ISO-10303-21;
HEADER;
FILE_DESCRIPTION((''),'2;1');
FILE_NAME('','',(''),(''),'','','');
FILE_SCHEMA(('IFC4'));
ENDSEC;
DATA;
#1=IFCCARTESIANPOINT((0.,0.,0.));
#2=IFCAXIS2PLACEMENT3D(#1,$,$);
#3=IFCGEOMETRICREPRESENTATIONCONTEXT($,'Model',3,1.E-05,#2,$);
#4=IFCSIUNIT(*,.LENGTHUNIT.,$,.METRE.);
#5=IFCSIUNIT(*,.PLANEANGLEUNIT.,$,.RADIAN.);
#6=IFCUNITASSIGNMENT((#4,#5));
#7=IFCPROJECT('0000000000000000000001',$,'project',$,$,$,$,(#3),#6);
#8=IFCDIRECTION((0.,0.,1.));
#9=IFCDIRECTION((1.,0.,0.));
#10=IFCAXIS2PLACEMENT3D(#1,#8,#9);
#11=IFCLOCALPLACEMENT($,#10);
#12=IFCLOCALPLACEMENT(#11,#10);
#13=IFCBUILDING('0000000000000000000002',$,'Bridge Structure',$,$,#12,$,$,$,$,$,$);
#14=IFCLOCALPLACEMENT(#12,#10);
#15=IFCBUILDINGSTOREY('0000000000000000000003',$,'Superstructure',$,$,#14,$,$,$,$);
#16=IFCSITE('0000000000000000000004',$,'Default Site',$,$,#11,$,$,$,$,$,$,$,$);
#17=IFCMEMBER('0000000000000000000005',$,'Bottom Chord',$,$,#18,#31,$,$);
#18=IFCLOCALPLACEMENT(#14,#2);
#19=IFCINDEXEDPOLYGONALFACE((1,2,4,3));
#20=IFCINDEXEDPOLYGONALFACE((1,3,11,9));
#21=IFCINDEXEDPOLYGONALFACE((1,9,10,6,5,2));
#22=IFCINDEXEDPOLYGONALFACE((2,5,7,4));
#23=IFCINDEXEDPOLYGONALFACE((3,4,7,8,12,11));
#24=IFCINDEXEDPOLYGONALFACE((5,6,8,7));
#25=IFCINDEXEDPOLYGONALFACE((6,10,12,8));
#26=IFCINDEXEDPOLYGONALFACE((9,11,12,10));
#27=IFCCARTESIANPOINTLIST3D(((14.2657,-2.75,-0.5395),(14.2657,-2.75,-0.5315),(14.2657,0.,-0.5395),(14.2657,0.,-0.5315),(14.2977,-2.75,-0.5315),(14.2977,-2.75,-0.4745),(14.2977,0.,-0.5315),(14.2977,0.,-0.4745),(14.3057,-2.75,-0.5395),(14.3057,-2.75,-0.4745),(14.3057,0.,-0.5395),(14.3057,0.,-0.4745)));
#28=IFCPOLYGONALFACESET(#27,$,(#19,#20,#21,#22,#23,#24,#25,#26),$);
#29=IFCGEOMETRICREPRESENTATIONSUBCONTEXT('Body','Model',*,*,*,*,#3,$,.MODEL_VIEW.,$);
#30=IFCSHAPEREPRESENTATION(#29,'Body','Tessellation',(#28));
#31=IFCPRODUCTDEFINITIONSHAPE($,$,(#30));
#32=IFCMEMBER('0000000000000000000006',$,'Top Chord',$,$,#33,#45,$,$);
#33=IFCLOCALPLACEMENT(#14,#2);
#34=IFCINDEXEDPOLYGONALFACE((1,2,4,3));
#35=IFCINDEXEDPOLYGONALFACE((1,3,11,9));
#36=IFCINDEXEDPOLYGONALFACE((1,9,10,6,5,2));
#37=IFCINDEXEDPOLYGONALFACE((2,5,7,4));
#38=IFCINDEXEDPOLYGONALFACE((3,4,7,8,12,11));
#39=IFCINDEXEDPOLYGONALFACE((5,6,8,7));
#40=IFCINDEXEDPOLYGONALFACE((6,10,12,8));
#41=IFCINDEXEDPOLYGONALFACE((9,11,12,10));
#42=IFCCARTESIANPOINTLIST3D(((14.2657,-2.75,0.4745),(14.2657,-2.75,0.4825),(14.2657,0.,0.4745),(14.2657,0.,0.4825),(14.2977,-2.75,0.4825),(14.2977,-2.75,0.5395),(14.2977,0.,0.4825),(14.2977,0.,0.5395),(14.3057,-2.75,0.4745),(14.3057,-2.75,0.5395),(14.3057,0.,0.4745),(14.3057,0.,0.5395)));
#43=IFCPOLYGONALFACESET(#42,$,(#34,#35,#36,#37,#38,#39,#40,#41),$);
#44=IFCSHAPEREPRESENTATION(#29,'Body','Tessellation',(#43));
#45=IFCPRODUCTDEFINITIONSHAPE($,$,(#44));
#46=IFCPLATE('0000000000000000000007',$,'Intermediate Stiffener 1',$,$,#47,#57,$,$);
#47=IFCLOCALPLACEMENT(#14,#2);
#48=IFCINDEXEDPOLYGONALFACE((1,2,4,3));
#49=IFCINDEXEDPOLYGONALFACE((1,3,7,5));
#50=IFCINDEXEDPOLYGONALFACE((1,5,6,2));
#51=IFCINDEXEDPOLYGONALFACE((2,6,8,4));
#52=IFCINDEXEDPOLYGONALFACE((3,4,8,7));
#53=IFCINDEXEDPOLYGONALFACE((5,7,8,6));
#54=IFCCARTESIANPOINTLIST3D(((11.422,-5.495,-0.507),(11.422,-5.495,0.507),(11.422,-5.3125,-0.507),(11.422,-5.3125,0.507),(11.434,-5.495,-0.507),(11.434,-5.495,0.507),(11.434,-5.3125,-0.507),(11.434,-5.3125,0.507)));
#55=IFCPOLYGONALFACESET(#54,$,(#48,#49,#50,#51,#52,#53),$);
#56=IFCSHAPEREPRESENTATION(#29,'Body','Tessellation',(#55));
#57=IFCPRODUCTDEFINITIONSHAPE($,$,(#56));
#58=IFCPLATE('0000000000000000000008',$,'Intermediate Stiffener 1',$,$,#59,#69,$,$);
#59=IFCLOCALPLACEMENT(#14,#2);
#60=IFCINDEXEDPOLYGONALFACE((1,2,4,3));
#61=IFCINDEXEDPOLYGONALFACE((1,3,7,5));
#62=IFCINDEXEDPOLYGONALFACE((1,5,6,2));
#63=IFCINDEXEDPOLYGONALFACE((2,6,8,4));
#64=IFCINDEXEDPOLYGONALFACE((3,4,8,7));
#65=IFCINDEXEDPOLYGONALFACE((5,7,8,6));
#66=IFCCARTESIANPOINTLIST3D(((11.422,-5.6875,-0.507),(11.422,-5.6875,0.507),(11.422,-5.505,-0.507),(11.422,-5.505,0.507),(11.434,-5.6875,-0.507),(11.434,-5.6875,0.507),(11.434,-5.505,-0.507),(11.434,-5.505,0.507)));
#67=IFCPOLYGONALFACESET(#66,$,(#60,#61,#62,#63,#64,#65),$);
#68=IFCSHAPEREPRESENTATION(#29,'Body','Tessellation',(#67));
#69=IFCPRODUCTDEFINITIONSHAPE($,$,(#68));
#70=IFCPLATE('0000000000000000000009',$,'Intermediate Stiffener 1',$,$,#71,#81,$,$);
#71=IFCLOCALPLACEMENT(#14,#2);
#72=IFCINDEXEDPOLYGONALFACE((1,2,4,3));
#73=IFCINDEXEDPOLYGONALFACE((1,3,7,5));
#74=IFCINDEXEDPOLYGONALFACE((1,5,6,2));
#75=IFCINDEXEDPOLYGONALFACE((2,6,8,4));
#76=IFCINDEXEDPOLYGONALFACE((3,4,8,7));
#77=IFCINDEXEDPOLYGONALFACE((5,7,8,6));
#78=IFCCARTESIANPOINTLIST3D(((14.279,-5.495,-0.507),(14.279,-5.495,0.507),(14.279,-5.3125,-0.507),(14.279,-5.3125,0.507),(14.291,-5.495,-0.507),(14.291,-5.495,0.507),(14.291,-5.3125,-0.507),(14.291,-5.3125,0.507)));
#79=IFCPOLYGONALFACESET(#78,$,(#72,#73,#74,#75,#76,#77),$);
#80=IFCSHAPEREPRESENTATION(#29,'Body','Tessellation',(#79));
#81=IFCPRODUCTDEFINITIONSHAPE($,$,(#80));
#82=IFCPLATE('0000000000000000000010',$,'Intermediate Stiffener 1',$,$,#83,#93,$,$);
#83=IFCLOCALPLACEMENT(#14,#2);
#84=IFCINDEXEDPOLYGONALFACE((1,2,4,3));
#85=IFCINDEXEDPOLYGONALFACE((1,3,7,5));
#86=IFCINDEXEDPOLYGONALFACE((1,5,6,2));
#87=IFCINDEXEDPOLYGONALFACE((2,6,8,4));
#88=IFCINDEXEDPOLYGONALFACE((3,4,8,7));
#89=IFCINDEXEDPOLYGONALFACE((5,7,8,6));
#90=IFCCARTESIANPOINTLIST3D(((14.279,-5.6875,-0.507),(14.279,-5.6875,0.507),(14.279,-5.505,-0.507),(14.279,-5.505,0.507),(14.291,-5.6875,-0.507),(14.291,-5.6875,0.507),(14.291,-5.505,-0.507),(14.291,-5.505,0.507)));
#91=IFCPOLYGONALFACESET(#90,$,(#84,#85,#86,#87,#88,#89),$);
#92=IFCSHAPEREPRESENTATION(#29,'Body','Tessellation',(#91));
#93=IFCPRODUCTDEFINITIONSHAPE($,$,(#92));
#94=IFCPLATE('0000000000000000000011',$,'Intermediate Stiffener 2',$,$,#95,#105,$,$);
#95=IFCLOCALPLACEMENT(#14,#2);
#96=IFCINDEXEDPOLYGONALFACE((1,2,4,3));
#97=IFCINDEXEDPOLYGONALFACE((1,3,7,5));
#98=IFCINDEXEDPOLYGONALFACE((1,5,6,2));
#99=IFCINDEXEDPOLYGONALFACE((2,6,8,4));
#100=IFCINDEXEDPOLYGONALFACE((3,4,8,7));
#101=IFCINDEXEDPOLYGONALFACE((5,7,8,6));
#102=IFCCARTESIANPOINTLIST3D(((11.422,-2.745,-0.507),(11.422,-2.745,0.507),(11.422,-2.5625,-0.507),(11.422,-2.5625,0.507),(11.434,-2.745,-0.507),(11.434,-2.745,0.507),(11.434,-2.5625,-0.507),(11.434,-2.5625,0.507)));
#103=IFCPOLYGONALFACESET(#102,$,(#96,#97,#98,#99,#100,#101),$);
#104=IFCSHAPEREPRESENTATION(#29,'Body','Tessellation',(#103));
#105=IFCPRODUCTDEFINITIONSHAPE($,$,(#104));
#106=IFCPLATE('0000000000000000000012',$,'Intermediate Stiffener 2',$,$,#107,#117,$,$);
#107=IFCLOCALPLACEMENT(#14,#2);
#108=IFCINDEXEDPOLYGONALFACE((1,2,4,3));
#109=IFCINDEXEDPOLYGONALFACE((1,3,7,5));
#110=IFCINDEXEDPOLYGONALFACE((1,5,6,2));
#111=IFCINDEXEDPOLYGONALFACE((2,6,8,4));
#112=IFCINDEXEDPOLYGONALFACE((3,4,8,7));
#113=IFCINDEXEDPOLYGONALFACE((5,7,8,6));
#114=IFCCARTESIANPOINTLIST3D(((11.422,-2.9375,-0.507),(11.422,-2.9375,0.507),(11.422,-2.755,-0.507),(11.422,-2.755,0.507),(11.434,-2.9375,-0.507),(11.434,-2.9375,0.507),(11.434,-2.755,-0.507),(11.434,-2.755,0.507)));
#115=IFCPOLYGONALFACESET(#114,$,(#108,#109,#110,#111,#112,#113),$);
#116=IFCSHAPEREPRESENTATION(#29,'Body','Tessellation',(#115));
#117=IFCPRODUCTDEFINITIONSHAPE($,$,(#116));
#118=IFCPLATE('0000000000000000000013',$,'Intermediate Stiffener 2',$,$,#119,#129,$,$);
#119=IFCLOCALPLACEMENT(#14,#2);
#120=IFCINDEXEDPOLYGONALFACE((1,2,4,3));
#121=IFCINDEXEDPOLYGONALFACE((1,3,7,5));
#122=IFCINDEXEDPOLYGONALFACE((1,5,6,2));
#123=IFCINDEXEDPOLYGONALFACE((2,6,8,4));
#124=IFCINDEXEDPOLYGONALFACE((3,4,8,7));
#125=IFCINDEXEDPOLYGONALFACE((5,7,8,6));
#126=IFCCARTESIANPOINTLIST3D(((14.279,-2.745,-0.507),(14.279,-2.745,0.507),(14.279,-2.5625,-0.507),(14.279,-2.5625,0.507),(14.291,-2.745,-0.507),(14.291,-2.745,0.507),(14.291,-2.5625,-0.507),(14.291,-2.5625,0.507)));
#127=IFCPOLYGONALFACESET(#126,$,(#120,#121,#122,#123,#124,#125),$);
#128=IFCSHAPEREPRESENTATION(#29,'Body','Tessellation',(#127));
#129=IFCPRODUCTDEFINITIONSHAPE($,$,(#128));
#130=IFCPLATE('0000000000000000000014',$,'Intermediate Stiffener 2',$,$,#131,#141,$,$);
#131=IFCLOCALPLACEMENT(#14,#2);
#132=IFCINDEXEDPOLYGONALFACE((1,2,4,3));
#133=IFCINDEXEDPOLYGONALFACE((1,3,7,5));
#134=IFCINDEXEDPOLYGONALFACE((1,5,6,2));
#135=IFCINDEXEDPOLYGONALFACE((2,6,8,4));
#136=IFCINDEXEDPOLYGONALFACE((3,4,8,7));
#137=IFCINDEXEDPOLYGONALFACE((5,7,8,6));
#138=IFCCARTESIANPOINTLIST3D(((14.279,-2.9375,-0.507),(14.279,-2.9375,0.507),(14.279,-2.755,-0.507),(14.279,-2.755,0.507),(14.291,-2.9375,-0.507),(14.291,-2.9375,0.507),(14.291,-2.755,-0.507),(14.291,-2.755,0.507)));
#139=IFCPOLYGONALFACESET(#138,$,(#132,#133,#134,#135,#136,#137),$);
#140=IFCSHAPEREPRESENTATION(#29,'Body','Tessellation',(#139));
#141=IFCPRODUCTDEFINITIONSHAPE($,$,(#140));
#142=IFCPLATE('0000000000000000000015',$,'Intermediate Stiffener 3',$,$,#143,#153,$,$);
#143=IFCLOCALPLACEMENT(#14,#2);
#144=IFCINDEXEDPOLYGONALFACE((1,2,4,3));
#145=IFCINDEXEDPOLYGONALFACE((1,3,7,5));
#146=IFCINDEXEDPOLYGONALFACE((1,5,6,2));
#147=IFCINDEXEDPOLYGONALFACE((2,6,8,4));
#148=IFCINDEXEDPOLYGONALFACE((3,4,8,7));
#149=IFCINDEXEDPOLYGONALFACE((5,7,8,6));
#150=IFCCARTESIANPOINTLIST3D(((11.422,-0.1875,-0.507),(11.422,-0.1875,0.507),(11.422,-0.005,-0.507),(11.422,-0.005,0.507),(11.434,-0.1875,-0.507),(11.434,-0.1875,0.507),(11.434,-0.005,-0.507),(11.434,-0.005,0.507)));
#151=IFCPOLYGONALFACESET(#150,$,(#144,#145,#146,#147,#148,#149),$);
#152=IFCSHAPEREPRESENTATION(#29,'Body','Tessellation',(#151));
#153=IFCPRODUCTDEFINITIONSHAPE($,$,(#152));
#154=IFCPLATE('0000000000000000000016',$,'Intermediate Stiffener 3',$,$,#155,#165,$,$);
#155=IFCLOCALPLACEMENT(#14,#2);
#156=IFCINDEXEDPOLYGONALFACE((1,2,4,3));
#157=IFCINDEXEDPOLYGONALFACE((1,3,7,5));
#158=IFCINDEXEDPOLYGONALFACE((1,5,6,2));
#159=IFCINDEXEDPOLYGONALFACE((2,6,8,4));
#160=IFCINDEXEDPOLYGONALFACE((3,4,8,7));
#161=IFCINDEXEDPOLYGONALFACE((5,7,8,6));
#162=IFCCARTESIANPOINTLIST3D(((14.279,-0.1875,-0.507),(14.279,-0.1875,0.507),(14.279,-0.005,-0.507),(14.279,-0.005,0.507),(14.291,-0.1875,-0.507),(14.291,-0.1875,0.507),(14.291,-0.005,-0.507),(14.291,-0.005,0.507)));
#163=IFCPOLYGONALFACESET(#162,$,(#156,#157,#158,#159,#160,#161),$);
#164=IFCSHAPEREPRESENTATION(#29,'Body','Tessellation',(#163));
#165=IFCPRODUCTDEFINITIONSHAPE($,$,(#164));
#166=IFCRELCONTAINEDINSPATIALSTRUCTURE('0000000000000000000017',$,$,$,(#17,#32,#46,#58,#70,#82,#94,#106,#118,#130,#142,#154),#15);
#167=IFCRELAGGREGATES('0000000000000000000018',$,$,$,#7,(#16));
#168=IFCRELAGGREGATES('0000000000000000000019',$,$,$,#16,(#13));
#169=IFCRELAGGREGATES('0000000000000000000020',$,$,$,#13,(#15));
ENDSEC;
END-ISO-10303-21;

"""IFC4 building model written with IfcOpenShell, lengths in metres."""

from ifc_helpers import new_model, si_unit, frame, origin, origin_with_axes, origin_2d_with_axis, place, context, subcontext, project, spatial, rectangle, l_section, extrude, element, save


model = new_model("IFC4")

# Units and contexts
model_context = context("Model", 3, precision=1e-05, world=origin())
body_context = subcontext(model_context, "Body", "Model", "MODEL_VIEW")
ifc_project = project(units=[si_unit("LENGTHUNIT", "METRE"), si_unit("PLANEANGLEUNIT", "RADIAN")], contexts=[model_context])

# Site, building, storey
site_placement = place(None, origin_with_axes())
site = spatial("IfcSite", under=ifc_project, at=site_placement, Name="Default Site")
building_placement = place(site_placement, origin_with_axes())
building = spatial("IfcBuilding", under=site, at=building_placement, Name="Bridge Structure")
storey_placement = place(building_placement, origin_with_axes())
storey = spatial("IfcBuildingStorey", under=building, at=storey_placement, Name="Superstructure")

# Members
for number, where, z_axis, x_axis, name in (
    (1, (14.2857, -2.75, -0.507), (0.0, 1.0, 0.0), (-1.0, 0.0, 0.0), "Bottom Chord"),
    (2, (14.2857, -2.75, 0.507), (0.0, 1.0, 0.0), (-1.0, 0.0, 0.0), "Top Chord"),
):
    element("IfcMember", number, at=place(storey_placement, frame(where, z_axis=z_axis, x_axis=x_axis)), inside=storey, Name=name, context=body_context, shape_type="SweptSolid", body=[
        extrude(l_section(Depth=0.065, Width=0.04, Thickness=0.008, at=origin_2d_with_axis()), origin_with_axes(), (0.0, 0.0, 1.0), 2.75),
    ])

# Plates
for number, where, z_axis, x_axis, name in (
    (3, (11.428, -5.4038, -0.507), (0.0, 0.0, 1.0), (1.0, 0.0, 0.0), "Intermediate Stiffener 1"),
    (4, (11.428, -5.5963, -0.507), (0.0, 0.0, 1.0), (1.0, 0.0, 0.0), "Intermediate Stiffener 1"),
    (5, (14.285, -5.4038, -0.507), (0.0, 0.0, 1.0), (1.0, 0.0, 0.0), "Intermediate Stiffener 1"),
    (6, (14.285, -5.5963, -0.507), (0.0, 0.0, 1.0), (1.0, 0.0, 0.0), "Intermediate Stiffener 1"),
    (7, (11.428, -2.6538, -0.507), (0.0, 0.0, 1.0), (1.0, 0.0, 0.0), "Intermediate Stiffener 2"),
    (8, (11.428, -2.8462, -0.507), (0.0, 0.0, 1.0), (1.0, 0.0, 0.0), "Intermediate Stiffener 2"),
    (9, (14.285, -2.6538, -0.507), (0.0, 0.0, 1.0), (1.0, 0.0, 0.0), "Intermediate Stiffener 2"),
    (10, (14.285, -2.8462, -0.507), (0.0, 0.0, 1.0), (1.0, 0.0, 0.0), "Intermediate Stiffener 2"),
    (11, (11.428, -0.0963, -0.507), (0.0, 0.0, 1.0), (1.0, 0.0, 0.0), "Intermediate Stiffener 3"),
    (12, (14.285, -0.0963, -0.507), (0.0, 0.0, 1.0), (1.0, 0.0, 0.0), "Intermediate Stiffener 3"),
):
    element("IfcPlate", number, at=place(storey_placement, frame(where, z_axis=z_axis, x_axis=x_axis)), inside=storey, Name=name, context=body_context, shape_type="SweptSolid", body=[
        extrude(rectangle(XDim=0.012, YDim=0.1825, at=origin_2d_with_axis()), origin_with_axes(), (0.0, 0.0, 1.0), 1.014),
    ])

save(model, "model.ifc")
